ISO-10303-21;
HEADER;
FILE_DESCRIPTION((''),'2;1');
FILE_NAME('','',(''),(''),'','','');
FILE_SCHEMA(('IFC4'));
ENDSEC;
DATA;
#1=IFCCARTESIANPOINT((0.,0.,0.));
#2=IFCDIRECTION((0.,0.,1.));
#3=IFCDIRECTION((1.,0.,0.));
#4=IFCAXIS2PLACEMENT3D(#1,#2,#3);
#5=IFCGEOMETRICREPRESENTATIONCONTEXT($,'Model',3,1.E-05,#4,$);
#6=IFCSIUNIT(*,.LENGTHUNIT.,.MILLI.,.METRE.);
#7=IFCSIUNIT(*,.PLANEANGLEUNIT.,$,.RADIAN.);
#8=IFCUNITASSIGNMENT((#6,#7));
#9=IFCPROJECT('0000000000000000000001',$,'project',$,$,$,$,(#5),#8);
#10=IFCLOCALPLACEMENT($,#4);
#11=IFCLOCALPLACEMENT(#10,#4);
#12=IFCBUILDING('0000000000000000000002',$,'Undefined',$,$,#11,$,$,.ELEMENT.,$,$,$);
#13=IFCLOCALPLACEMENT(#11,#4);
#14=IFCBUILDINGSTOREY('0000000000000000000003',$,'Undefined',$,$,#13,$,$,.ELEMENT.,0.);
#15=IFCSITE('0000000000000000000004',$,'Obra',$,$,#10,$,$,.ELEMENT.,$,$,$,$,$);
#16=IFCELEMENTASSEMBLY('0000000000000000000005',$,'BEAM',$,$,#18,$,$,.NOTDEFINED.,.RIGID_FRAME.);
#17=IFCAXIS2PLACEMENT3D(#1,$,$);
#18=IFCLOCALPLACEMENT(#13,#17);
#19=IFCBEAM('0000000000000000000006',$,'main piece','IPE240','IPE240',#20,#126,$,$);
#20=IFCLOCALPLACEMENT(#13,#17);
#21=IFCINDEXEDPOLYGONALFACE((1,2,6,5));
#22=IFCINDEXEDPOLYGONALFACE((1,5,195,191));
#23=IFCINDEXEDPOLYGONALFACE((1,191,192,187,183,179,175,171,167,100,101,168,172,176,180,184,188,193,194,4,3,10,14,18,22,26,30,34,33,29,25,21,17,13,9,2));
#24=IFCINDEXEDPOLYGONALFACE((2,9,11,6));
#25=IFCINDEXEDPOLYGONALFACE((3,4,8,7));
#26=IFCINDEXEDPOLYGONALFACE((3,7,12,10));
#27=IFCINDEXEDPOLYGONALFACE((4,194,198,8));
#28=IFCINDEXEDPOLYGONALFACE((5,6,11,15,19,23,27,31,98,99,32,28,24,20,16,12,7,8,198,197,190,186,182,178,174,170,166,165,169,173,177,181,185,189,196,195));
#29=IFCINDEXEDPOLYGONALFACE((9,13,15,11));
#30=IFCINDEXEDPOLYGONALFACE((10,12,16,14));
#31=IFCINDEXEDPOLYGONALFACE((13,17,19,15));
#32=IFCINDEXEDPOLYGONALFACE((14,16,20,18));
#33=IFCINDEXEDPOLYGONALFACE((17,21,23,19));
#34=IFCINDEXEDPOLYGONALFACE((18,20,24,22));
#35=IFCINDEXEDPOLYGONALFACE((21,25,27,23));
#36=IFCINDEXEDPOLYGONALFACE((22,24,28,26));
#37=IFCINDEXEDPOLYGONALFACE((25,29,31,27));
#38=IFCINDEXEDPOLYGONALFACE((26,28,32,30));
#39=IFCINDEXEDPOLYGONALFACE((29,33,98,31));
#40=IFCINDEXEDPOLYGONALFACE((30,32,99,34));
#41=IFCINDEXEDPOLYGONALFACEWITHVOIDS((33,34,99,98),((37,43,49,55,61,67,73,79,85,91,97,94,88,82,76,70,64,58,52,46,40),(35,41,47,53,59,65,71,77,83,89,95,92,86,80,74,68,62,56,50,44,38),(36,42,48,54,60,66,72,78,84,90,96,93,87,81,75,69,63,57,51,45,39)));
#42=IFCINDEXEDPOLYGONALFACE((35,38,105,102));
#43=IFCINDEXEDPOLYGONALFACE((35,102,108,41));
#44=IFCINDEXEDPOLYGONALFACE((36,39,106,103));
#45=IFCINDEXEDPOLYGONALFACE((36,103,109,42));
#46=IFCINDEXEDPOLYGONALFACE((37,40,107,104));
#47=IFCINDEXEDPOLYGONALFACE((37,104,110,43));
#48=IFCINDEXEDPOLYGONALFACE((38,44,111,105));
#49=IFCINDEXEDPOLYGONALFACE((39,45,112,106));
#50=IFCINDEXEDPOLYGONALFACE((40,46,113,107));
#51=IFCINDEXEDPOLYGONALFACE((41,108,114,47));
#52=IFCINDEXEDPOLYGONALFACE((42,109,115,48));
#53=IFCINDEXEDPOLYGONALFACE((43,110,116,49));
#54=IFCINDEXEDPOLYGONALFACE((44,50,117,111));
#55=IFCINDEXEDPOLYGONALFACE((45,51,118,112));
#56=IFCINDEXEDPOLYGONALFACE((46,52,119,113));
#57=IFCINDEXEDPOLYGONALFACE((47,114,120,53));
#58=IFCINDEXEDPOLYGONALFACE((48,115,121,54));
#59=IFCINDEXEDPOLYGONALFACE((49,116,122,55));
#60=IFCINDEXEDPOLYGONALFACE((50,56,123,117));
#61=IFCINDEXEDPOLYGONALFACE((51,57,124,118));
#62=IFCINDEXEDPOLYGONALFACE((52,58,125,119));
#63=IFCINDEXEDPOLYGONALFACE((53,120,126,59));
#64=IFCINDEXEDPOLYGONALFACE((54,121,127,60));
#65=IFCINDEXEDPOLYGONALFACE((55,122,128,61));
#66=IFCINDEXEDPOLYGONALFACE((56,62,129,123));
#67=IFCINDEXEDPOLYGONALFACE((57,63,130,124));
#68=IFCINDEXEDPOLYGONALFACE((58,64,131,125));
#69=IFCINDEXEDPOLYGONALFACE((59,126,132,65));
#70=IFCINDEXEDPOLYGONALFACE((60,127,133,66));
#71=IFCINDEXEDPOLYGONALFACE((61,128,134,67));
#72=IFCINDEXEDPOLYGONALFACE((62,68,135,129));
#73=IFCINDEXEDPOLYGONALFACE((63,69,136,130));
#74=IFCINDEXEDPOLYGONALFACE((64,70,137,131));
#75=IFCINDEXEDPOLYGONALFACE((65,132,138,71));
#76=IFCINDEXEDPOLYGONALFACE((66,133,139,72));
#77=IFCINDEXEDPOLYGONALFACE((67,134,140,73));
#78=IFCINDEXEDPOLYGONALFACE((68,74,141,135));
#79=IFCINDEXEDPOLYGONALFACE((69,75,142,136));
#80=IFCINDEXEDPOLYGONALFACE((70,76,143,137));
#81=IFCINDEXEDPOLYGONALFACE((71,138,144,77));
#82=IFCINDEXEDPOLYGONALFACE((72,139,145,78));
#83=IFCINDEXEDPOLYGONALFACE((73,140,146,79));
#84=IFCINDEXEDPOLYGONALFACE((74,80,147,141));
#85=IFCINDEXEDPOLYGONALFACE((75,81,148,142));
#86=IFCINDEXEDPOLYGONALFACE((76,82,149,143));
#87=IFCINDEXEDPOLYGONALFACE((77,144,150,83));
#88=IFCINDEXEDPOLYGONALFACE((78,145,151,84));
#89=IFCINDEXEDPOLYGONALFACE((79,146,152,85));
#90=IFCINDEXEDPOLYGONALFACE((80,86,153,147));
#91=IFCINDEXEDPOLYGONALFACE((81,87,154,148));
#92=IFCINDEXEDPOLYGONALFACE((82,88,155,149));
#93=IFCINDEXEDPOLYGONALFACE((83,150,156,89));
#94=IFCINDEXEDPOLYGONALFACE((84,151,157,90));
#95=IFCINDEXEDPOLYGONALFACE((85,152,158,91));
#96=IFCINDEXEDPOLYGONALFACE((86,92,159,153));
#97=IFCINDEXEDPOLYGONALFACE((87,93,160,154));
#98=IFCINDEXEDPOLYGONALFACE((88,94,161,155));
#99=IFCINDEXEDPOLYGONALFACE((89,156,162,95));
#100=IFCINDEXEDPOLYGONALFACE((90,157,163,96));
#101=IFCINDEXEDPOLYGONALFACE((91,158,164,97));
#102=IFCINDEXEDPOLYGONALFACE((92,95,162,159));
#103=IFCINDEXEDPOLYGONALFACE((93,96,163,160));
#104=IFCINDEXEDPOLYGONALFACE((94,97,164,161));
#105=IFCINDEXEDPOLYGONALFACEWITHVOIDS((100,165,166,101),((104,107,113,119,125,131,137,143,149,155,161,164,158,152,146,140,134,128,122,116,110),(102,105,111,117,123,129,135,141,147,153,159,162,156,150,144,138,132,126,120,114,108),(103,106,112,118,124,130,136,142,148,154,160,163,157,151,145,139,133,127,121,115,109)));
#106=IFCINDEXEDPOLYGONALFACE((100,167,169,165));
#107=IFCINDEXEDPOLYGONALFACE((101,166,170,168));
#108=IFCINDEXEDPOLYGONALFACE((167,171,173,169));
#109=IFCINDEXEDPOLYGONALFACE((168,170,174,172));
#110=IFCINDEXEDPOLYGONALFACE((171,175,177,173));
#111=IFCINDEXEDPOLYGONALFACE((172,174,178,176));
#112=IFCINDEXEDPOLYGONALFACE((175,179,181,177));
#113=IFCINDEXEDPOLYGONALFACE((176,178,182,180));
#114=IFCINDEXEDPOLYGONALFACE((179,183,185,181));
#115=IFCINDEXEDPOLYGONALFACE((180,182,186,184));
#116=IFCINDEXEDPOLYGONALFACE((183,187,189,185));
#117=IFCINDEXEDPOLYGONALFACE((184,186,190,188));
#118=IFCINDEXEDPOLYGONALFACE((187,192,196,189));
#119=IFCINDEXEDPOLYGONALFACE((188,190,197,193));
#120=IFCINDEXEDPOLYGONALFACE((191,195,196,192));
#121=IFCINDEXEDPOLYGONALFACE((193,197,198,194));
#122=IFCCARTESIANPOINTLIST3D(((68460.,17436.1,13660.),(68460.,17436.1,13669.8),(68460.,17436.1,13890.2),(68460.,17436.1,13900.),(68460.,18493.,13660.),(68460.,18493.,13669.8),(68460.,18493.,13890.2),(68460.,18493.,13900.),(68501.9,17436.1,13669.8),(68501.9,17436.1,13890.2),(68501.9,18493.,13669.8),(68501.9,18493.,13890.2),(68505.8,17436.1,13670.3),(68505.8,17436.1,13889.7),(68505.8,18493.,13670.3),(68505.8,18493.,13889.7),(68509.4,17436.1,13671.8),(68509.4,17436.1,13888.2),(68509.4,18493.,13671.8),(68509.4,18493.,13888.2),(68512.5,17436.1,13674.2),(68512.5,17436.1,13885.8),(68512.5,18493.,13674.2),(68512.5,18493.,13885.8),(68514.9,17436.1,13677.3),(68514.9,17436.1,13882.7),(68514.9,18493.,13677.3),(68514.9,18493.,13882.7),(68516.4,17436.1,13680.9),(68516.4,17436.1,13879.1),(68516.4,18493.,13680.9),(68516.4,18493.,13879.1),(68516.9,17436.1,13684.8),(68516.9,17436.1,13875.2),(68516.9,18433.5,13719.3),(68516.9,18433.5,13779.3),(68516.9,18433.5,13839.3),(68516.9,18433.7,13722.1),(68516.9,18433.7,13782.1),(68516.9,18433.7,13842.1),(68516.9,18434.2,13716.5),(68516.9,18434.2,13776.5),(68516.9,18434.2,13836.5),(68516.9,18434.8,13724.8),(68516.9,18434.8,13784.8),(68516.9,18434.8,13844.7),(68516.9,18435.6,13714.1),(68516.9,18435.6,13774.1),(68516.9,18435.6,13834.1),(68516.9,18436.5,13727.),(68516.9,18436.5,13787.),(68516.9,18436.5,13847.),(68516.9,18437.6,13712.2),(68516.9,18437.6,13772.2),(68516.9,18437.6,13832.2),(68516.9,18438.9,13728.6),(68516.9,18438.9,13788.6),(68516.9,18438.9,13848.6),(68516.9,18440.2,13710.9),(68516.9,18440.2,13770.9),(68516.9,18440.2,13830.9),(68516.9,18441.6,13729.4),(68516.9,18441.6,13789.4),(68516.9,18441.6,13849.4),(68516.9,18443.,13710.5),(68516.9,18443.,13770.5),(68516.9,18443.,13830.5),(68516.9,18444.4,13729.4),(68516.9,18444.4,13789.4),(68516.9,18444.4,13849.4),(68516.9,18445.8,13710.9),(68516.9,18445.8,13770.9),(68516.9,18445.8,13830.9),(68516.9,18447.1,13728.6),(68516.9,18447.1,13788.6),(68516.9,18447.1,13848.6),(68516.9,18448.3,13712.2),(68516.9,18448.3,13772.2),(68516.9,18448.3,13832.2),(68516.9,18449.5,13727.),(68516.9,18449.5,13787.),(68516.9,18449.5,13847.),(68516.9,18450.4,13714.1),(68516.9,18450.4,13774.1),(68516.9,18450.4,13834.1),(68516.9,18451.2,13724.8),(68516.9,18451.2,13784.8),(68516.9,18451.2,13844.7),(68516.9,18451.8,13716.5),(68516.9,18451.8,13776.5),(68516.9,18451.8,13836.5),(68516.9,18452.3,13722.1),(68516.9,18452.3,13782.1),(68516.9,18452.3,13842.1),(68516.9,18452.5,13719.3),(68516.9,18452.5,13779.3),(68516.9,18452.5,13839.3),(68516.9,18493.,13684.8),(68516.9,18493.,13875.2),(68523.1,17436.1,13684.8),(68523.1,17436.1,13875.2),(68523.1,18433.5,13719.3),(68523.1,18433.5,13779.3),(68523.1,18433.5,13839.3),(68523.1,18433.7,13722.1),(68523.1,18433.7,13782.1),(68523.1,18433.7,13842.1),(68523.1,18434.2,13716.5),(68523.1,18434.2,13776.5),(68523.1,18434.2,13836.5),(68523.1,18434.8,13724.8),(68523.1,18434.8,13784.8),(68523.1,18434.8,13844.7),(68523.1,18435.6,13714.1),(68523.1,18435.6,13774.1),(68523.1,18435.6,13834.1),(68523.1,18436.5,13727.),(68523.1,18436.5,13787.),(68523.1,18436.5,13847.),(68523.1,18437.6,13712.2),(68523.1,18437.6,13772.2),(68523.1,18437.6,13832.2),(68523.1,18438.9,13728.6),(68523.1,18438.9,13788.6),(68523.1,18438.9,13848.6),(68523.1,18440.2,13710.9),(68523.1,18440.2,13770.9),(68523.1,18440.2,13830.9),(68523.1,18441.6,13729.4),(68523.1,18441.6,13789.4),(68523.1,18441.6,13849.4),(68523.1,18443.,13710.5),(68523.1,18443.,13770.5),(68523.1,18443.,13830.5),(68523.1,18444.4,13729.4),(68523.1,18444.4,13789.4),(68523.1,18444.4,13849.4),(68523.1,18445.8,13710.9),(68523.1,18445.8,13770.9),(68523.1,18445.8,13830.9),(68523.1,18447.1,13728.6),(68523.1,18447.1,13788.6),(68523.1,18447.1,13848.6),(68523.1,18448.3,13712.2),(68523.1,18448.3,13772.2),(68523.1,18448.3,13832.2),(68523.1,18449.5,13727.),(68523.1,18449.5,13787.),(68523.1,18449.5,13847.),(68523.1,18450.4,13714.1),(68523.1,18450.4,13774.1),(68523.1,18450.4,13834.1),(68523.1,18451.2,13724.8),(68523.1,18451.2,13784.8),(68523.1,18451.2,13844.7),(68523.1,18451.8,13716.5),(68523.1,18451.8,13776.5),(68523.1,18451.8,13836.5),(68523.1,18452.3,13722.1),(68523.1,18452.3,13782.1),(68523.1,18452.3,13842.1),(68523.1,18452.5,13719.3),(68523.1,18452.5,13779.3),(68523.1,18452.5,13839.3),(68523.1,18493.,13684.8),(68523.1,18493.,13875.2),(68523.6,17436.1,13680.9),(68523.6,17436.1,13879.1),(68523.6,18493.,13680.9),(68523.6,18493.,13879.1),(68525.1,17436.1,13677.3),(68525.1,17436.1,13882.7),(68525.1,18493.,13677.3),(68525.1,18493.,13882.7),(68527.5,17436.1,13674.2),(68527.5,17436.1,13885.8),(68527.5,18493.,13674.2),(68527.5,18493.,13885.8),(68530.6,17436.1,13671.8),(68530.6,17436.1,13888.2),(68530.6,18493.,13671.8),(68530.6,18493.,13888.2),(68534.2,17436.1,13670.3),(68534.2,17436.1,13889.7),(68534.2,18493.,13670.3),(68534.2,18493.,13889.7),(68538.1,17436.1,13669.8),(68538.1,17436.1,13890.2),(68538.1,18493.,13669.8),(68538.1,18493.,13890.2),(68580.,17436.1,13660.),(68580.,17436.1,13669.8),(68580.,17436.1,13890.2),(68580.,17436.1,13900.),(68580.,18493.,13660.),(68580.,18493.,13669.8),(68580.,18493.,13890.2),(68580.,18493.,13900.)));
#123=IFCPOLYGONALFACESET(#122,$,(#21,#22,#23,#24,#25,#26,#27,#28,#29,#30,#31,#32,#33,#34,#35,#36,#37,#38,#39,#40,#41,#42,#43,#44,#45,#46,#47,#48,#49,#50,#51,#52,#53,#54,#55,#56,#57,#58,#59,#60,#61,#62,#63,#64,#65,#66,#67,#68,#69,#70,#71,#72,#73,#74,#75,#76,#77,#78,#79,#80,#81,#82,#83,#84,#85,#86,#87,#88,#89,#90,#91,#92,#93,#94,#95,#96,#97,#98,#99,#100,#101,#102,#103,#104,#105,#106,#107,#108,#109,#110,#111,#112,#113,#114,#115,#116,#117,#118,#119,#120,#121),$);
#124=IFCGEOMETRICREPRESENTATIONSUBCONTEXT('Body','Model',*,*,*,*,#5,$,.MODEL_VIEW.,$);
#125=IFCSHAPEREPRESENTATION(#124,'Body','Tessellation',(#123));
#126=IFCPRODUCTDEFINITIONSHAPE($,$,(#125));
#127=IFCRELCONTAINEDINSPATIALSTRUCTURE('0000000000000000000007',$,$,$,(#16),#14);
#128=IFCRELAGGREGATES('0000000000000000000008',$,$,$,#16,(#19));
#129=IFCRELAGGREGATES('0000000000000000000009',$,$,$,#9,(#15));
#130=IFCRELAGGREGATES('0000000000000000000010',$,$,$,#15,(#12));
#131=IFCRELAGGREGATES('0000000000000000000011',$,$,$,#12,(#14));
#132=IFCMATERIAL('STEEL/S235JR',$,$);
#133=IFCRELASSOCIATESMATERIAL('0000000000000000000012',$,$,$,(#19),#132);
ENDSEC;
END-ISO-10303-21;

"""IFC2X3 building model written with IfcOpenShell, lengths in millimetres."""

from ifc_helpers import new_model, si_unit, frame, origin_with_axes, origin_2d_with_axis, place, context, subcontext, project, spatial, rectangle, circle, i_section, extrude, clip, halfspace, source, transform, mapped, material, element, aggregate, save


model = new_model("IFC2X3")

# Units and contexts
model_context = context("Model", 3, precision=1e-05, world=origin_with_axes())
body_context = subcontext(model_context, "Body", "Model", "MODEL_VIEW")
ifc_project = project(units=[si_unit("LENGTHUNIT", "METRE", prefix="MILLI"), si_unit("PLANEANGLEUNIT", "RADIAN")], contexts=[model_context])

# Site, building, storey
site_placement = place(None, origin_with_axes())
site = spatial("IfcSite", under=ifc_project, at=site_placement, Name="Obra", CompositionType="ELEMENT")
building_placement = place(site_placement, origin_with_axes())
building = spatial("IfcBuilding", under=site, at=building_placement, Name="Undefined", CompositionType="ELEMENT")
storey_placement = place(building_placement, origin_with_axes())
storey = spatial("IfcBuildingStorey", under=building, at=storey_placement, Name="Undefined", CompositionType="ELEMENT", Elevation=0.0)

# Element assembly, beam, openings
ifc_material_1 = material(Name="STEEL/S235JR")
shared_shape_1 = source(origin_with_axes(), body_context, "Body", "SweptSolid", [
    extrude(circle(Radius=9.5, at=origin_2d_with_axis()), frame((0.0, -3.2, 0.0), z_axis=(0.0, 1.0, 0.0), x_axis=(1.0, 0.0, 0.0)), (0.0, 0.0, 1.0), 6.4),
])
assembly_1_placement = place(storey_placement, origin_with_axes())
assembly_1 = element("IfcElementAssembly", 1, at=assembly_1_placement, inside=storey, Name="BEAM", AssemblyPlace="NOTDEFINED", PredefinedType="RIGID_FRAME")
beam_1_placement = place(assembly_1_placement, frame((68520.0, 17345.4, 13780.0), z_axis=(0.0, 0.0, 1.0), x_axis=(0.0, 1.0, 0.0)))
beam_1 = element("IfcBeam", 2, at=beam_1_placement, material=ifc_material_1, Name="main piece", Description="IPE240", ObjectType="IPE240", context=body_context, shape_type="Clipping", body=[
    clip(clip(extrude(i_section(OverallWidth=120.0, OverallDepth=240.0, WebThickness=6.2, FlangeThickness=9.8, FilletRadius=15.0, at=origin_2d_with_axis()), frame((1147.6, 0.0, 0.0), z_axis=(-1.0, 0.0, 0.0), x_axis=(0.0, -1.0, 0.0)), (0.0, 0.0, 1.0), 1147.6), halfspace(frame((90.8, 60.0, -120.0), z_axis=(-1.0, 0.0, 0.0), x_axis=(0.0, 0.0, 1.0)), False)), halfspace(frame((1147.6, 0.0, -220.0), z_axis=(-1.0, -0.000001, 0.0), x_axis=(-0.000001, 1.0, 0.0)), True)),
])
opening_1_placement = place(assembly_1_placement, frame((68520.0, 17345.4, 13780.0), z_axis=(0.0, 0.0, 1.0), x_axis=(0.0, 1.0, 0.0)))
element("IfcOpeningElement", 3, at=opening_1_placement, cuts=beam_1, ObjectType="Recess", context=body_context, shape_type="SweptSolid", body=[
    extrude(rectangle(XDim=25.8, YDim=68.9, at=origin_2d_with_axis()), frame((1182.1, 61.0, -108.1), z_axis=(0.000001, -1.0, 0.0), x_axis=(0.0, 0.0, -1.0)), (0.0, 0.0, 1.0), 122.0),
])
opening_2_placement = place(assembly_1_placement, frame((68520.0, 17345.4, 13780.0), z_axis=(0.0, 0.0, 1.0), x_axis=(0.0, 1.0, 0.0)))
element("IfcOpeningElement", 4, at=opening_2_placement, cuts=beam_1, ObjectType="Recess", context=body_context, shape_type="SweptSolid", body=[
    extrude(rectangle(XDim=25.8, YDim=68.9, at=origin_2d_with_axis()), frame((1182.1, 61.0, 108.1), z_axis=(0.000001, -1.0, 0.0), x_axis=(0.0, 0.0, -1.0)), (0.0, 0.0, 1.0), 122.0),
])
opening_3_placement = place(assembly_1_placement, frame((68520.0, 18493.0, 13890.2), z_axis=(0.000001, -1.0, 0.0), x_axis=(0.0, 0.0, -1.0)))
element("IfcOpeningElement", 5, at=opening_3_placement, cuts=beam_1, ObjectType="Opening", context=body_context, shape_type="MappedRepresentation", body=[
    mapped(shared_shape_1, transform((170.2, 0.0, 50.0))),
    mapped(shared_shape_1, transform((110.2, 0.0, 50.0))),
    mapped(shared_shape_1, transform((50.2, 0.0, 50.0))),
])

aggregate(assembly_1, [beam_1])

save(model, "model.ifc")
